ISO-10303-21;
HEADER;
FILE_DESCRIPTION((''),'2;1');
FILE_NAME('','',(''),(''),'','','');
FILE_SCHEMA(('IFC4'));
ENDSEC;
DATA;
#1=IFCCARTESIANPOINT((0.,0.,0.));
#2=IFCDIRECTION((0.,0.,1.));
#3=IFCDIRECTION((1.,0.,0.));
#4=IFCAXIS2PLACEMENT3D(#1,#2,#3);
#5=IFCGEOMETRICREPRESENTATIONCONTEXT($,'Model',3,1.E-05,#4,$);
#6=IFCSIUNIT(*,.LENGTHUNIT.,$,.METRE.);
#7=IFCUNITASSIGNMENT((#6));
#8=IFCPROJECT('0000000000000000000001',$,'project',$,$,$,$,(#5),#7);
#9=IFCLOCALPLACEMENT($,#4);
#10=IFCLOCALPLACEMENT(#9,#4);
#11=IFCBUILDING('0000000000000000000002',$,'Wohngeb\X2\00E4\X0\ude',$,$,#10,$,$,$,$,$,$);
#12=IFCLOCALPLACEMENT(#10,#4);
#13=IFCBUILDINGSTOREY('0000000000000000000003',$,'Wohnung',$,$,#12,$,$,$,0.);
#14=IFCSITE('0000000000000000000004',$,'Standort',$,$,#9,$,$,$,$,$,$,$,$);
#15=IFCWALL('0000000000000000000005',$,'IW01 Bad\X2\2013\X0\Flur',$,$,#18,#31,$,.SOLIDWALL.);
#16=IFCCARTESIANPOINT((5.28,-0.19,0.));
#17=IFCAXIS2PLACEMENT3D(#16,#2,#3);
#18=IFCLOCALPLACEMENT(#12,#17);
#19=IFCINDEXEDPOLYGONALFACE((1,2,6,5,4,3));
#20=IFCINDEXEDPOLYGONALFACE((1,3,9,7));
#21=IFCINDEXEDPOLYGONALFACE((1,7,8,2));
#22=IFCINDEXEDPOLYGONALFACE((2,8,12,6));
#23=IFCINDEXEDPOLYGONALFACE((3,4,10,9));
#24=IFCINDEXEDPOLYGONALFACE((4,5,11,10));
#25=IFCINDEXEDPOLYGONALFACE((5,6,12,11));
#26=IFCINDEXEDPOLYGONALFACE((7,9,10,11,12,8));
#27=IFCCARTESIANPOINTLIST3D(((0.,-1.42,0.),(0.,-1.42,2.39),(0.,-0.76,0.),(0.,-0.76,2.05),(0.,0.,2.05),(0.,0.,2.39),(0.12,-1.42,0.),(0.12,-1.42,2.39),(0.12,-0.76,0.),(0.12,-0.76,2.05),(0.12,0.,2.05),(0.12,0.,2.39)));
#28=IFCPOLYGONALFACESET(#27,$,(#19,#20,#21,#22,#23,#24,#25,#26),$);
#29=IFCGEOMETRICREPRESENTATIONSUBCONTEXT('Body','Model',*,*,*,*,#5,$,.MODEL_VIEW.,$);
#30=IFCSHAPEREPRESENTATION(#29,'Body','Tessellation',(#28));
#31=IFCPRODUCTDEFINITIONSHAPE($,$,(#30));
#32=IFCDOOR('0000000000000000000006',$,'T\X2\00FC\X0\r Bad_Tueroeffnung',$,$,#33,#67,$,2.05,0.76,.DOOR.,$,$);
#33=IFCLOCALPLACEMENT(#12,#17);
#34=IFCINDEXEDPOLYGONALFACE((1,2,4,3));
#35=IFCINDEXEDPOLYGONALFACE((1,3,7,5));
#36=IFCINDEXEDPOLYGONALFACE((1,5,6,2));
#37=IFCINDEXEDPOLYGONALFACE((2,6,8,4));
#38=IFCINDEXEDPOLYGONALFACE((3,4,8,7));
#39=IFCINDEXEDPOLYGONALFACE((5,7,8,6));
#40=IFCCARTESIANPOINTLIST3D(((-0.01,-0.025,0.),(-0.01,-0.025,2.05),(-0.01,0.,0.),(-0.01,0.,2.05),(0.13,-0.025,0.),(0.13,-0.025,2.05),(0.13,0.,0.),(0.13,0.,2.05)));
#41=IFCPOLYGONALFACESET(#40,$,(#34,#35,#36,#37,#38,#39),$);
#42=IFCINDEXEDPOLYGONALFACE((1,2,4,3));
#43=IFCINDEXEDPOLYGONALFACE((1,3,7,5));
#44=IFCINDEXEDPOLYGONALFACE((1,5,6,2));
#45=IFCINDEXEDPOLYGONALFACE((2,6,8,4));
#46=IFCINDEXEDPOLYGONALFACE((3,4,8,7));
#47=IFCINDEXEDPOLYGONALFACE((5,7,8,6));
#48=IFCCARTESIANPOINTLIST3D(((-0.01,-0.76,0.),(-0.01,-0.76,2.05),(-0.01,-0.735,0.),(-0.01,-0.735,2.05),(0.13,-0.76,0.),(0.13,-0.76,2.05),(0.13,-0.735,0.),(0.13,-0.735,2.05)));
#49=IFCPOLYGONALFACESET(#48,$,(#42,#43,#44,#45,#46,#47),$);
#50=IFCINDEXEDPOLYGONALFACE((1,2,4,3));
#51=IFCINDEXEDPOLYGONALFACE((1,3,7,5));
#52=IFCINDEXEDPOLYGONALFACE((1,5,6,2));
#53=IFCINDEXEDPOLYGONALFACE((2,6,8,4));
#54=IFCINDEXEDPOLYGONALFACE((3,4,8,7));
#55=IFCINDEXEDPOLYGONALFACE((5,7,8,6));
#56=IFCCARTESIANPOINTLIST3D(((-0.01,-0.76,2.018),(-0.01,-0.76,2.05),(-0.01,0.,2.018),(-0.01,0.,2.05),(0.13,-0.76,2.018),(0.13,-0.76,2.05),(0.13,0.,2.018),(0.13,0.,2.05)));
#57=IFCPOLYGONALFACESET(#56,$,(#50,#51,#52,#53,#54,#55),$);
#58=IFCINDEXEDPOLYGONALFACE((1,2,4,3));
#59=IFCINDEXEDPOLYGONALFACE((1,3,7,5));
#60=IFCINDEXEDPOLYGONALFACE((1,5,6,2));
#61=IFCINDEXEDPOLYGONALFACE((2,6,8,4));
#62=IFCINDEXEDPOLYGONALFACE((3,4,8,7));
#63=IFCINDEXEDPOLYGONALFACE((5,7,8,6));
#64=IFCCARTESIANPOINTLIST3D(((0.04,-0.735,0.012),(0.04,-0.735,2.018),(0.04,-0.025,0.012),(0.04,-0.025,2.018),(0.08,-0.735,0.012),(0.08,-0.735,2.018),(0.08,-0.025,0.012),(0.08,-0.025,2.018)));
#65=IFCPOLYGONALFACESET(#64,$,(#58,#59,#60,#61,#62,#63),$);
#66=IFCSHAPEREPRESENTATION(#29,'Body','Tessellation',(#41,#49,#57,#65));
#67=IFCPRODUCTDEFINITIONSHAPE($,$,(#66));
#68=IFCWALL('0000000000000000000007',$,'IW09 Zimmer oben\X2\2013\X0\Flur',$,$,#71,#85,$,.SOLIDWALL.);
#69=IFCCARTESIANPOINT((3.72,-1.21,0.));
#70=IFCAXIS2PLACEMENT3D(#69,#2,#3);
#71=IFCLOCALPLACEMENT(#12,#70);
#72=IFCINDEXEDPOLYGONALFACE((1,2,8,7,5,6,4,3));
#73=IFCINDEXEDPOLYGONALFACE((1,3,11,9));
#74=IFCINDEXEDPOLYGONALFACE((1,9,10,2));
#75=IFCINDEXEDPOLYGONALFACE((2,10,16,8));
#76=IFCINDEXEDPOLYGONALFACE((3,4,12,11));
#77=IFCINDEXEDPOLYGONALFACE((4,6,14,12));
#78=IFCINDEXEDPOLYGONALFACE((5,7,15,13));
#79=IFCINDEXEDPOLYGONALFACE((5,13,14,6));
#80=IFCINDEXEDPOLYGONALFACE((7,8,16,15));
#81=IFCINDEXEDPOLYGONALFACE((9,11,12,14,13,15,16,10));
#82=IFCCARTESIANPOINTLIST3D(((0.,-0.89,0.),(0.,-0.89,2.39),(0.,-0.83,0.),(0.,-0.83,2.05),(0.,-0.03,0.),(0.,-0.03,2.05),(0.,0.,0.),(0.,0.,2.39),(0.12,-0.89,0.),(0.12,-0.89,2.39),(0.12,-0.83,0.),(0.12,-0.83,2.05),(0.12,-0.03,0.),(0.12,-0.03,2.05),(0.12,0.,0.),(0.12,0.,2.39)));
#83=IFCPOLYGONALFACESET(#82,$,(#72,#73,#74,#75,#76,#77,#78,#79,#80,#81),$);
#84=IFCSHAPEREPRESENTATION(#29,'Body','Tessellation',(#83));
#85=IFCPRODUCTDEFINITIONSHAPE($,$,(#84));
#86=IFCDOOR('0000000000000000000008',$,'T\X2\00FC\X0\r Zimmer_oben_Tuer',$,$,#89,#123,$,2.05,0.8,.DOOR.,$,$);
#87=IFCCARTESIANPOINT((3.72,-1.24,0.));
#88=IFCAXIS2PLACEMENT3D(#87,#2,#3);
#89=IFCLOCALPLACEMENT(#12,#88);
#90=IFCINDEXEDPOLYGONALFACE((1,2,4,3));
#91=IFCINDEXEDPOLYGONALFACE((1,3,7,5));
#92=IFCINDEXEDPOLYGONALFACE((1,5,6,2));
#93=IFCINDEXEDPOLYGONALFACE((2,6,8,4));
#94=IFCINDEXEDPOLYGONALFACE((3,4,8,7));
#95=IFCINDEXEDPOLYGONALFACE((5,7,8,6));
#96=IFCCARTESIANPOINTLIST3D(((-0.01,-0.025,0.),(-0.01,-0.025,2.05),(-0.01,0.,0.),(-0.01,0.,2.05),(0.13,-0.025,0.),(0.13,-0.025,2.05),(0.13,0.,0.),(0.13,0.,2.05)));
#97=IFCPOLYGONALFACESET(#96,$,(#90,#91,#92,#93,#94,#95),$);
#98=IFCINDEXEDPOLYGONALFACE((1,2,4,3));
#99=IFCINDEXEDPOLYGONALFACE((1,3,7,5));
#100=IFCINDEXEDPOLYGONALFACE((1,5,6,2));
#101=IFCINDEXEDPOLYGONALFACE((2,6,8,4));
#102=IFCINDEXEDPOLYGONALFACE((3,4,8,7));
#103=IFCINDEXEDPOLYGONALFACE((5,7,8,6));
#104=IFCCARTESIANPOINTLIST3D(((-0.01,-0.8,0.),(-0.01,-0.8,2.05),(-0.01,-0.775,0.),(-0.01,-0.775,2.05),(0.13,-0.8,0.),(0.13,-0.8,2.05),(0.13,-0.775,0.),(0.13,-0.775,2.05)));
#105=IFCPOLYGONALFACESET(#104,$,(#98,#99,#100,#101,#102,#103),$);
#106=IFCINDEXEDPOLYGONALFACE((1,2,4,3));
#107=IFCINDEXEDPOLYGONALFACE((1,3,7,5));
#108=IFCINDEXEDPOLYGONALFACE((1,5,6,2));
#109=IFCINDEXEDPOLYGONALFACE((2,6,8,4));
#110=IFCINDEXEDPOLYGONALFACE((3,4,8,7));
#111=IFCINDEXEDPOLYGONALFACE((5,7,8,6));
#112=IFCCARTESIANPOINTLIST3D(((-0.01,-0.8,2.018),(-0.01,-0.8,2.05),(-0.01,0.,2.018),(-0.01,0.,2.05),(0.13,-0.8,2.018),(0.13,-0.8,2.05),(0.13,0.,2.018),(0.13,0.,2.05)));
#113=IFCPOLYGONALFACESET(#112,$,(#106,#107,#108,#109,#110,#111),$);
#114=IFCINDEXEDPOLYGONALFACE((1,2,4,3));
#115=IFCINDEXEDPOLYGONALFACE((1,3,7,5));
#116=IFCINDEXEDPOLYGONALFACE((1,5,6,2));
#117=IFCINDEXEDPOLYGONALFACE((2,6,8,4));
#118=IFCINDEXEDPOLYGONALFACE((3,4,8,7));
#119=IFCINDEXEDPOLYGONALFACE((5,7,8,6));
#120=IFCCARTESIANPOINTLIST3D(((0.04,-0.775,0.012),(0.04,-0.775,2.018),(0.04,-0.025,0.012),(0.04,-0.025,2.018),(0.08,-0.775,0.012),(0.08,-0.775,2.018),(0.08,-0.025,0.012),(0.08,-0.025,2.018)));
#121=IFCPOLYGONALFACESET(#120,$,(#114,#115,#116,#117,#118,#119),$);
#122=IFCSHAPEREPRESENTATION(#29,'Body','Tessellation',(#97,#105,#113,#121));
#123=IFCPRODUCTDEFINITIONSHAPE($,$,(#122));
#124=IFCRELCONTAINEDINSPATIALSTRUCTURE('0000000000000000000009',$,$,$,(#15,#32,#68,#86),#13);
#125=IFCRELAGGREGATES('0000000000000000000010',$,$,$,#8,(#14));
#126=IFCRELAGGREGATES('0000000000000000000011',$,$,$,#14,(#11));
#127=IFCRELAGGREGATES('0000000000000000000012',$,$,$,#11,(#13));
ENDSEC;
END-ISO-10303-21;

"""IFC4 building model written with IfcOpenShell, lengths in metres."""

from ifc_helpers import new_model, si_unit, frame, origin, origin_with_axes, place, context, subcontext, project, spatial, polyline, outline, extrude, element, fill, save


model = new_model("IFC4")

# Units and contexts
model_context = context("Model", 3, precision=1e-05, world=origin_with_axes())
body_context = subcontext(model_context, "Body", "Model", "MODEL_VIEW")
ifc_project = project(units=[si_unit("LENGTHUNIT", "METRE")], contexts=[model_context])

# Site, building, storey
site_placement = place(None, origin_with_axes())
site = spatial("IfcSite", under=ifc_project, at=site_placement, Name="Standort")
building_placement = place(site_placement, origin_with_axes())
building = spatial("IfcBuilding", under=site, at=building_placement, Name="Wohngebäude")
storey_placement = place(building_placement, origin_with_axes())
storey = spatial("IfcBuildingStorey", under=building, at=storey_placement, Name="Wohnung", Elevation=0.0)

# Walls, openings, doors
wall_1_placement = place(storey_placement, frame((5.28, -0.19, 0.0), z_axis=(0.0, 0.0, 1.0), x_axis=(1.0, 0.0, 0.0)))
wall_1 = element("IfcWall", 1, at=wall_1_placement, inside=storey, Name="IW01 Bad–Flur", PredefinedType="SOLIDWALL", context=body_context, shape_type="SweptSolid", body=[
    extrude(outline(polyline([(0.0, 0.0), (0.0, -1.42), (0.12, -1.42), (0.12, 0.0), (0.0, 0.0)])), origin(), (0.0, 0.0, 1.0), 2.39),
])
opening_1_placement = place(wall_1_placement, origin_with_axes())
opening_1 = element("IfcOpeningElement", 2, at=opening_1_placement, cuts=wall_1, PredefinedType="OPENING", context=body_context, shape_type="SweptSolid", body=[
    extrude(outline(polyline([(-0.005, 0.0), (-0.005, -0.76), (0.125, -0.76), (0.125, 0.0), (-0.005, 0.0)])), origin(), (0.0, 0.0, 1.0), 2.05),
])
door_1_placement = place(storey_placement, frame((5.28, -0.19, 0.0), z_axis=(0.0, 0.0, 1.0), x_axis=(1.0, 0.0, 0.0)))
door_1 = element("IfcDoor", 3, at=door_1_placement, inside=storey, Name="Tür Bad_Tueroeffnung", OverallHeight=2.05, OverallWidth=0.76, PredefinedType="DOOR", context=body_context, shape_type="SweptSolid", body=[
    extrude(outline(polyline([(-0.01, 0.0), (-0.01, -0.025), (0.13, -0.025), (0.13, 0.0), (-0.01, 0.0)])), origin(), (0.0, 0.0, 1.0), 2.05),
    extrude(outline(polyline([(-0.01, -0.735), (-0.01, -0.76), (0.13, -0.76), (0.13, -0.735), (-0.01, -0.735)])), origin(), (0.0, 0.0, 1.0), 2.05),
    extrude(outline(polyline([(-0.01, 0.0), (-0.01, -0.76), (0.13, -0.76), (0.13, 0.0), (-0.01, 0.0)])), frame((0.0, 0.0, 2.018)), (0.0, 0.0, 1.0), 0.032),
    extrude(outline(polyline([(0.04, -0.025), (0.04, -0.735), (0.08, -0.735), (0.08, -0.025), (0.04, -0.025)])), frame((0.0, 0.0, 0.012)), (0.0, 0.0, 1.0), 2.006),
])
fill(opening_1, door_1)
wall_2_placement = place(storey_placement, frame((3.72, -1.21, 0.0), z_axis=(0.0, 0.0, 1.0), x_axis=(1.0, 0.0, 0.0)))
wall_2 = element("IfcWall", 4, at=wall_2_placement, inside=storey, Name="IW09 Zimmer oben–Flur", PredefinedType="SOLIDWALL", context=body_context, shape_type="SweptSolid", body=[
    extrude(outline(polyline([(0.0, 0.0), (0.0, -0.89), (0.12, -0.89), (0.12, 0.0), (0.0, 0.0)])), origin(), (0.0, 0.0, 1.0), 2.39),
])
opening_2_placement = place(wall_2_placement, frame((0.0, -0.03, 0.0), z_axis=(0.0, 0.0, 1.0), x_axis=(1.0, 0.0, 0.0)))
opening_2 = element("IfcOpeningElement", 5, at=opening_2_placement, cuts=wall_2, PredefinedType="OPENING", context=body_context, shape_type="SweptSolid", body=[
    extrude(outline(polyline([(-0.005, 0.0), (-0.005, -0.8), (0.125, -0.8), (0.125, 0.0), (-0.005, 0.0)])), origin(), (0.0, 0.0, 1.0), 2.05),
])
door_2_placement = place(storey_placement, frame((3.72, -1.24, 0.0), z_axis=(0.0, 0.0, 1.0), x_axis=(1.0, 0.0, 0.0)))
door_2 = element("IfcDoor", 6, at=door_2_placement, inside=storey, Name="Tür Zimmer_oben_Tuer", OverallHeight=2.05, OverallWidth=0.8, PredefinedType="DOOR", context=body_context, shape_type="SweptSolid", body=[
    extrude(outline(polyline([(-0.01, 0.0), (-0.01, -0.025), (0.13, -0.025), (0.13, 0.0), (-0.01, 0.0)])), origin(), (0.0, 0.0, 1.0), 2.05),
    extrude(outline(polyline([(-0.01, -0.775), (-0.01, -0.8), (0.13, -0.8), (0.13, -0.775), (-0.01, -0.775)])), origin(), (0.0, 0.0, 1.0), 2.05),
    extrude(outline(polyline([(-0.01, 0.0), (-0.01, -0.8), (0.13, -0.8), (0.13, 0.0), (-0.01, 0.0)])), frame((0.0, 0.0, 2.018)), (0.0, 0.0, 1.0), 0.032),
    extrude(outline(polyline([(0.04, -0.025), (0.04, -0.775), (0.08, -0.775), (0.08, -0.025), (0.04, -0.025)])), frame((0.0, 0.0, 0.012)), (0.0, 0.0, 1.0), 2.006),
])
fill(opening_2, door_2)

save(model, "model.ifc")
